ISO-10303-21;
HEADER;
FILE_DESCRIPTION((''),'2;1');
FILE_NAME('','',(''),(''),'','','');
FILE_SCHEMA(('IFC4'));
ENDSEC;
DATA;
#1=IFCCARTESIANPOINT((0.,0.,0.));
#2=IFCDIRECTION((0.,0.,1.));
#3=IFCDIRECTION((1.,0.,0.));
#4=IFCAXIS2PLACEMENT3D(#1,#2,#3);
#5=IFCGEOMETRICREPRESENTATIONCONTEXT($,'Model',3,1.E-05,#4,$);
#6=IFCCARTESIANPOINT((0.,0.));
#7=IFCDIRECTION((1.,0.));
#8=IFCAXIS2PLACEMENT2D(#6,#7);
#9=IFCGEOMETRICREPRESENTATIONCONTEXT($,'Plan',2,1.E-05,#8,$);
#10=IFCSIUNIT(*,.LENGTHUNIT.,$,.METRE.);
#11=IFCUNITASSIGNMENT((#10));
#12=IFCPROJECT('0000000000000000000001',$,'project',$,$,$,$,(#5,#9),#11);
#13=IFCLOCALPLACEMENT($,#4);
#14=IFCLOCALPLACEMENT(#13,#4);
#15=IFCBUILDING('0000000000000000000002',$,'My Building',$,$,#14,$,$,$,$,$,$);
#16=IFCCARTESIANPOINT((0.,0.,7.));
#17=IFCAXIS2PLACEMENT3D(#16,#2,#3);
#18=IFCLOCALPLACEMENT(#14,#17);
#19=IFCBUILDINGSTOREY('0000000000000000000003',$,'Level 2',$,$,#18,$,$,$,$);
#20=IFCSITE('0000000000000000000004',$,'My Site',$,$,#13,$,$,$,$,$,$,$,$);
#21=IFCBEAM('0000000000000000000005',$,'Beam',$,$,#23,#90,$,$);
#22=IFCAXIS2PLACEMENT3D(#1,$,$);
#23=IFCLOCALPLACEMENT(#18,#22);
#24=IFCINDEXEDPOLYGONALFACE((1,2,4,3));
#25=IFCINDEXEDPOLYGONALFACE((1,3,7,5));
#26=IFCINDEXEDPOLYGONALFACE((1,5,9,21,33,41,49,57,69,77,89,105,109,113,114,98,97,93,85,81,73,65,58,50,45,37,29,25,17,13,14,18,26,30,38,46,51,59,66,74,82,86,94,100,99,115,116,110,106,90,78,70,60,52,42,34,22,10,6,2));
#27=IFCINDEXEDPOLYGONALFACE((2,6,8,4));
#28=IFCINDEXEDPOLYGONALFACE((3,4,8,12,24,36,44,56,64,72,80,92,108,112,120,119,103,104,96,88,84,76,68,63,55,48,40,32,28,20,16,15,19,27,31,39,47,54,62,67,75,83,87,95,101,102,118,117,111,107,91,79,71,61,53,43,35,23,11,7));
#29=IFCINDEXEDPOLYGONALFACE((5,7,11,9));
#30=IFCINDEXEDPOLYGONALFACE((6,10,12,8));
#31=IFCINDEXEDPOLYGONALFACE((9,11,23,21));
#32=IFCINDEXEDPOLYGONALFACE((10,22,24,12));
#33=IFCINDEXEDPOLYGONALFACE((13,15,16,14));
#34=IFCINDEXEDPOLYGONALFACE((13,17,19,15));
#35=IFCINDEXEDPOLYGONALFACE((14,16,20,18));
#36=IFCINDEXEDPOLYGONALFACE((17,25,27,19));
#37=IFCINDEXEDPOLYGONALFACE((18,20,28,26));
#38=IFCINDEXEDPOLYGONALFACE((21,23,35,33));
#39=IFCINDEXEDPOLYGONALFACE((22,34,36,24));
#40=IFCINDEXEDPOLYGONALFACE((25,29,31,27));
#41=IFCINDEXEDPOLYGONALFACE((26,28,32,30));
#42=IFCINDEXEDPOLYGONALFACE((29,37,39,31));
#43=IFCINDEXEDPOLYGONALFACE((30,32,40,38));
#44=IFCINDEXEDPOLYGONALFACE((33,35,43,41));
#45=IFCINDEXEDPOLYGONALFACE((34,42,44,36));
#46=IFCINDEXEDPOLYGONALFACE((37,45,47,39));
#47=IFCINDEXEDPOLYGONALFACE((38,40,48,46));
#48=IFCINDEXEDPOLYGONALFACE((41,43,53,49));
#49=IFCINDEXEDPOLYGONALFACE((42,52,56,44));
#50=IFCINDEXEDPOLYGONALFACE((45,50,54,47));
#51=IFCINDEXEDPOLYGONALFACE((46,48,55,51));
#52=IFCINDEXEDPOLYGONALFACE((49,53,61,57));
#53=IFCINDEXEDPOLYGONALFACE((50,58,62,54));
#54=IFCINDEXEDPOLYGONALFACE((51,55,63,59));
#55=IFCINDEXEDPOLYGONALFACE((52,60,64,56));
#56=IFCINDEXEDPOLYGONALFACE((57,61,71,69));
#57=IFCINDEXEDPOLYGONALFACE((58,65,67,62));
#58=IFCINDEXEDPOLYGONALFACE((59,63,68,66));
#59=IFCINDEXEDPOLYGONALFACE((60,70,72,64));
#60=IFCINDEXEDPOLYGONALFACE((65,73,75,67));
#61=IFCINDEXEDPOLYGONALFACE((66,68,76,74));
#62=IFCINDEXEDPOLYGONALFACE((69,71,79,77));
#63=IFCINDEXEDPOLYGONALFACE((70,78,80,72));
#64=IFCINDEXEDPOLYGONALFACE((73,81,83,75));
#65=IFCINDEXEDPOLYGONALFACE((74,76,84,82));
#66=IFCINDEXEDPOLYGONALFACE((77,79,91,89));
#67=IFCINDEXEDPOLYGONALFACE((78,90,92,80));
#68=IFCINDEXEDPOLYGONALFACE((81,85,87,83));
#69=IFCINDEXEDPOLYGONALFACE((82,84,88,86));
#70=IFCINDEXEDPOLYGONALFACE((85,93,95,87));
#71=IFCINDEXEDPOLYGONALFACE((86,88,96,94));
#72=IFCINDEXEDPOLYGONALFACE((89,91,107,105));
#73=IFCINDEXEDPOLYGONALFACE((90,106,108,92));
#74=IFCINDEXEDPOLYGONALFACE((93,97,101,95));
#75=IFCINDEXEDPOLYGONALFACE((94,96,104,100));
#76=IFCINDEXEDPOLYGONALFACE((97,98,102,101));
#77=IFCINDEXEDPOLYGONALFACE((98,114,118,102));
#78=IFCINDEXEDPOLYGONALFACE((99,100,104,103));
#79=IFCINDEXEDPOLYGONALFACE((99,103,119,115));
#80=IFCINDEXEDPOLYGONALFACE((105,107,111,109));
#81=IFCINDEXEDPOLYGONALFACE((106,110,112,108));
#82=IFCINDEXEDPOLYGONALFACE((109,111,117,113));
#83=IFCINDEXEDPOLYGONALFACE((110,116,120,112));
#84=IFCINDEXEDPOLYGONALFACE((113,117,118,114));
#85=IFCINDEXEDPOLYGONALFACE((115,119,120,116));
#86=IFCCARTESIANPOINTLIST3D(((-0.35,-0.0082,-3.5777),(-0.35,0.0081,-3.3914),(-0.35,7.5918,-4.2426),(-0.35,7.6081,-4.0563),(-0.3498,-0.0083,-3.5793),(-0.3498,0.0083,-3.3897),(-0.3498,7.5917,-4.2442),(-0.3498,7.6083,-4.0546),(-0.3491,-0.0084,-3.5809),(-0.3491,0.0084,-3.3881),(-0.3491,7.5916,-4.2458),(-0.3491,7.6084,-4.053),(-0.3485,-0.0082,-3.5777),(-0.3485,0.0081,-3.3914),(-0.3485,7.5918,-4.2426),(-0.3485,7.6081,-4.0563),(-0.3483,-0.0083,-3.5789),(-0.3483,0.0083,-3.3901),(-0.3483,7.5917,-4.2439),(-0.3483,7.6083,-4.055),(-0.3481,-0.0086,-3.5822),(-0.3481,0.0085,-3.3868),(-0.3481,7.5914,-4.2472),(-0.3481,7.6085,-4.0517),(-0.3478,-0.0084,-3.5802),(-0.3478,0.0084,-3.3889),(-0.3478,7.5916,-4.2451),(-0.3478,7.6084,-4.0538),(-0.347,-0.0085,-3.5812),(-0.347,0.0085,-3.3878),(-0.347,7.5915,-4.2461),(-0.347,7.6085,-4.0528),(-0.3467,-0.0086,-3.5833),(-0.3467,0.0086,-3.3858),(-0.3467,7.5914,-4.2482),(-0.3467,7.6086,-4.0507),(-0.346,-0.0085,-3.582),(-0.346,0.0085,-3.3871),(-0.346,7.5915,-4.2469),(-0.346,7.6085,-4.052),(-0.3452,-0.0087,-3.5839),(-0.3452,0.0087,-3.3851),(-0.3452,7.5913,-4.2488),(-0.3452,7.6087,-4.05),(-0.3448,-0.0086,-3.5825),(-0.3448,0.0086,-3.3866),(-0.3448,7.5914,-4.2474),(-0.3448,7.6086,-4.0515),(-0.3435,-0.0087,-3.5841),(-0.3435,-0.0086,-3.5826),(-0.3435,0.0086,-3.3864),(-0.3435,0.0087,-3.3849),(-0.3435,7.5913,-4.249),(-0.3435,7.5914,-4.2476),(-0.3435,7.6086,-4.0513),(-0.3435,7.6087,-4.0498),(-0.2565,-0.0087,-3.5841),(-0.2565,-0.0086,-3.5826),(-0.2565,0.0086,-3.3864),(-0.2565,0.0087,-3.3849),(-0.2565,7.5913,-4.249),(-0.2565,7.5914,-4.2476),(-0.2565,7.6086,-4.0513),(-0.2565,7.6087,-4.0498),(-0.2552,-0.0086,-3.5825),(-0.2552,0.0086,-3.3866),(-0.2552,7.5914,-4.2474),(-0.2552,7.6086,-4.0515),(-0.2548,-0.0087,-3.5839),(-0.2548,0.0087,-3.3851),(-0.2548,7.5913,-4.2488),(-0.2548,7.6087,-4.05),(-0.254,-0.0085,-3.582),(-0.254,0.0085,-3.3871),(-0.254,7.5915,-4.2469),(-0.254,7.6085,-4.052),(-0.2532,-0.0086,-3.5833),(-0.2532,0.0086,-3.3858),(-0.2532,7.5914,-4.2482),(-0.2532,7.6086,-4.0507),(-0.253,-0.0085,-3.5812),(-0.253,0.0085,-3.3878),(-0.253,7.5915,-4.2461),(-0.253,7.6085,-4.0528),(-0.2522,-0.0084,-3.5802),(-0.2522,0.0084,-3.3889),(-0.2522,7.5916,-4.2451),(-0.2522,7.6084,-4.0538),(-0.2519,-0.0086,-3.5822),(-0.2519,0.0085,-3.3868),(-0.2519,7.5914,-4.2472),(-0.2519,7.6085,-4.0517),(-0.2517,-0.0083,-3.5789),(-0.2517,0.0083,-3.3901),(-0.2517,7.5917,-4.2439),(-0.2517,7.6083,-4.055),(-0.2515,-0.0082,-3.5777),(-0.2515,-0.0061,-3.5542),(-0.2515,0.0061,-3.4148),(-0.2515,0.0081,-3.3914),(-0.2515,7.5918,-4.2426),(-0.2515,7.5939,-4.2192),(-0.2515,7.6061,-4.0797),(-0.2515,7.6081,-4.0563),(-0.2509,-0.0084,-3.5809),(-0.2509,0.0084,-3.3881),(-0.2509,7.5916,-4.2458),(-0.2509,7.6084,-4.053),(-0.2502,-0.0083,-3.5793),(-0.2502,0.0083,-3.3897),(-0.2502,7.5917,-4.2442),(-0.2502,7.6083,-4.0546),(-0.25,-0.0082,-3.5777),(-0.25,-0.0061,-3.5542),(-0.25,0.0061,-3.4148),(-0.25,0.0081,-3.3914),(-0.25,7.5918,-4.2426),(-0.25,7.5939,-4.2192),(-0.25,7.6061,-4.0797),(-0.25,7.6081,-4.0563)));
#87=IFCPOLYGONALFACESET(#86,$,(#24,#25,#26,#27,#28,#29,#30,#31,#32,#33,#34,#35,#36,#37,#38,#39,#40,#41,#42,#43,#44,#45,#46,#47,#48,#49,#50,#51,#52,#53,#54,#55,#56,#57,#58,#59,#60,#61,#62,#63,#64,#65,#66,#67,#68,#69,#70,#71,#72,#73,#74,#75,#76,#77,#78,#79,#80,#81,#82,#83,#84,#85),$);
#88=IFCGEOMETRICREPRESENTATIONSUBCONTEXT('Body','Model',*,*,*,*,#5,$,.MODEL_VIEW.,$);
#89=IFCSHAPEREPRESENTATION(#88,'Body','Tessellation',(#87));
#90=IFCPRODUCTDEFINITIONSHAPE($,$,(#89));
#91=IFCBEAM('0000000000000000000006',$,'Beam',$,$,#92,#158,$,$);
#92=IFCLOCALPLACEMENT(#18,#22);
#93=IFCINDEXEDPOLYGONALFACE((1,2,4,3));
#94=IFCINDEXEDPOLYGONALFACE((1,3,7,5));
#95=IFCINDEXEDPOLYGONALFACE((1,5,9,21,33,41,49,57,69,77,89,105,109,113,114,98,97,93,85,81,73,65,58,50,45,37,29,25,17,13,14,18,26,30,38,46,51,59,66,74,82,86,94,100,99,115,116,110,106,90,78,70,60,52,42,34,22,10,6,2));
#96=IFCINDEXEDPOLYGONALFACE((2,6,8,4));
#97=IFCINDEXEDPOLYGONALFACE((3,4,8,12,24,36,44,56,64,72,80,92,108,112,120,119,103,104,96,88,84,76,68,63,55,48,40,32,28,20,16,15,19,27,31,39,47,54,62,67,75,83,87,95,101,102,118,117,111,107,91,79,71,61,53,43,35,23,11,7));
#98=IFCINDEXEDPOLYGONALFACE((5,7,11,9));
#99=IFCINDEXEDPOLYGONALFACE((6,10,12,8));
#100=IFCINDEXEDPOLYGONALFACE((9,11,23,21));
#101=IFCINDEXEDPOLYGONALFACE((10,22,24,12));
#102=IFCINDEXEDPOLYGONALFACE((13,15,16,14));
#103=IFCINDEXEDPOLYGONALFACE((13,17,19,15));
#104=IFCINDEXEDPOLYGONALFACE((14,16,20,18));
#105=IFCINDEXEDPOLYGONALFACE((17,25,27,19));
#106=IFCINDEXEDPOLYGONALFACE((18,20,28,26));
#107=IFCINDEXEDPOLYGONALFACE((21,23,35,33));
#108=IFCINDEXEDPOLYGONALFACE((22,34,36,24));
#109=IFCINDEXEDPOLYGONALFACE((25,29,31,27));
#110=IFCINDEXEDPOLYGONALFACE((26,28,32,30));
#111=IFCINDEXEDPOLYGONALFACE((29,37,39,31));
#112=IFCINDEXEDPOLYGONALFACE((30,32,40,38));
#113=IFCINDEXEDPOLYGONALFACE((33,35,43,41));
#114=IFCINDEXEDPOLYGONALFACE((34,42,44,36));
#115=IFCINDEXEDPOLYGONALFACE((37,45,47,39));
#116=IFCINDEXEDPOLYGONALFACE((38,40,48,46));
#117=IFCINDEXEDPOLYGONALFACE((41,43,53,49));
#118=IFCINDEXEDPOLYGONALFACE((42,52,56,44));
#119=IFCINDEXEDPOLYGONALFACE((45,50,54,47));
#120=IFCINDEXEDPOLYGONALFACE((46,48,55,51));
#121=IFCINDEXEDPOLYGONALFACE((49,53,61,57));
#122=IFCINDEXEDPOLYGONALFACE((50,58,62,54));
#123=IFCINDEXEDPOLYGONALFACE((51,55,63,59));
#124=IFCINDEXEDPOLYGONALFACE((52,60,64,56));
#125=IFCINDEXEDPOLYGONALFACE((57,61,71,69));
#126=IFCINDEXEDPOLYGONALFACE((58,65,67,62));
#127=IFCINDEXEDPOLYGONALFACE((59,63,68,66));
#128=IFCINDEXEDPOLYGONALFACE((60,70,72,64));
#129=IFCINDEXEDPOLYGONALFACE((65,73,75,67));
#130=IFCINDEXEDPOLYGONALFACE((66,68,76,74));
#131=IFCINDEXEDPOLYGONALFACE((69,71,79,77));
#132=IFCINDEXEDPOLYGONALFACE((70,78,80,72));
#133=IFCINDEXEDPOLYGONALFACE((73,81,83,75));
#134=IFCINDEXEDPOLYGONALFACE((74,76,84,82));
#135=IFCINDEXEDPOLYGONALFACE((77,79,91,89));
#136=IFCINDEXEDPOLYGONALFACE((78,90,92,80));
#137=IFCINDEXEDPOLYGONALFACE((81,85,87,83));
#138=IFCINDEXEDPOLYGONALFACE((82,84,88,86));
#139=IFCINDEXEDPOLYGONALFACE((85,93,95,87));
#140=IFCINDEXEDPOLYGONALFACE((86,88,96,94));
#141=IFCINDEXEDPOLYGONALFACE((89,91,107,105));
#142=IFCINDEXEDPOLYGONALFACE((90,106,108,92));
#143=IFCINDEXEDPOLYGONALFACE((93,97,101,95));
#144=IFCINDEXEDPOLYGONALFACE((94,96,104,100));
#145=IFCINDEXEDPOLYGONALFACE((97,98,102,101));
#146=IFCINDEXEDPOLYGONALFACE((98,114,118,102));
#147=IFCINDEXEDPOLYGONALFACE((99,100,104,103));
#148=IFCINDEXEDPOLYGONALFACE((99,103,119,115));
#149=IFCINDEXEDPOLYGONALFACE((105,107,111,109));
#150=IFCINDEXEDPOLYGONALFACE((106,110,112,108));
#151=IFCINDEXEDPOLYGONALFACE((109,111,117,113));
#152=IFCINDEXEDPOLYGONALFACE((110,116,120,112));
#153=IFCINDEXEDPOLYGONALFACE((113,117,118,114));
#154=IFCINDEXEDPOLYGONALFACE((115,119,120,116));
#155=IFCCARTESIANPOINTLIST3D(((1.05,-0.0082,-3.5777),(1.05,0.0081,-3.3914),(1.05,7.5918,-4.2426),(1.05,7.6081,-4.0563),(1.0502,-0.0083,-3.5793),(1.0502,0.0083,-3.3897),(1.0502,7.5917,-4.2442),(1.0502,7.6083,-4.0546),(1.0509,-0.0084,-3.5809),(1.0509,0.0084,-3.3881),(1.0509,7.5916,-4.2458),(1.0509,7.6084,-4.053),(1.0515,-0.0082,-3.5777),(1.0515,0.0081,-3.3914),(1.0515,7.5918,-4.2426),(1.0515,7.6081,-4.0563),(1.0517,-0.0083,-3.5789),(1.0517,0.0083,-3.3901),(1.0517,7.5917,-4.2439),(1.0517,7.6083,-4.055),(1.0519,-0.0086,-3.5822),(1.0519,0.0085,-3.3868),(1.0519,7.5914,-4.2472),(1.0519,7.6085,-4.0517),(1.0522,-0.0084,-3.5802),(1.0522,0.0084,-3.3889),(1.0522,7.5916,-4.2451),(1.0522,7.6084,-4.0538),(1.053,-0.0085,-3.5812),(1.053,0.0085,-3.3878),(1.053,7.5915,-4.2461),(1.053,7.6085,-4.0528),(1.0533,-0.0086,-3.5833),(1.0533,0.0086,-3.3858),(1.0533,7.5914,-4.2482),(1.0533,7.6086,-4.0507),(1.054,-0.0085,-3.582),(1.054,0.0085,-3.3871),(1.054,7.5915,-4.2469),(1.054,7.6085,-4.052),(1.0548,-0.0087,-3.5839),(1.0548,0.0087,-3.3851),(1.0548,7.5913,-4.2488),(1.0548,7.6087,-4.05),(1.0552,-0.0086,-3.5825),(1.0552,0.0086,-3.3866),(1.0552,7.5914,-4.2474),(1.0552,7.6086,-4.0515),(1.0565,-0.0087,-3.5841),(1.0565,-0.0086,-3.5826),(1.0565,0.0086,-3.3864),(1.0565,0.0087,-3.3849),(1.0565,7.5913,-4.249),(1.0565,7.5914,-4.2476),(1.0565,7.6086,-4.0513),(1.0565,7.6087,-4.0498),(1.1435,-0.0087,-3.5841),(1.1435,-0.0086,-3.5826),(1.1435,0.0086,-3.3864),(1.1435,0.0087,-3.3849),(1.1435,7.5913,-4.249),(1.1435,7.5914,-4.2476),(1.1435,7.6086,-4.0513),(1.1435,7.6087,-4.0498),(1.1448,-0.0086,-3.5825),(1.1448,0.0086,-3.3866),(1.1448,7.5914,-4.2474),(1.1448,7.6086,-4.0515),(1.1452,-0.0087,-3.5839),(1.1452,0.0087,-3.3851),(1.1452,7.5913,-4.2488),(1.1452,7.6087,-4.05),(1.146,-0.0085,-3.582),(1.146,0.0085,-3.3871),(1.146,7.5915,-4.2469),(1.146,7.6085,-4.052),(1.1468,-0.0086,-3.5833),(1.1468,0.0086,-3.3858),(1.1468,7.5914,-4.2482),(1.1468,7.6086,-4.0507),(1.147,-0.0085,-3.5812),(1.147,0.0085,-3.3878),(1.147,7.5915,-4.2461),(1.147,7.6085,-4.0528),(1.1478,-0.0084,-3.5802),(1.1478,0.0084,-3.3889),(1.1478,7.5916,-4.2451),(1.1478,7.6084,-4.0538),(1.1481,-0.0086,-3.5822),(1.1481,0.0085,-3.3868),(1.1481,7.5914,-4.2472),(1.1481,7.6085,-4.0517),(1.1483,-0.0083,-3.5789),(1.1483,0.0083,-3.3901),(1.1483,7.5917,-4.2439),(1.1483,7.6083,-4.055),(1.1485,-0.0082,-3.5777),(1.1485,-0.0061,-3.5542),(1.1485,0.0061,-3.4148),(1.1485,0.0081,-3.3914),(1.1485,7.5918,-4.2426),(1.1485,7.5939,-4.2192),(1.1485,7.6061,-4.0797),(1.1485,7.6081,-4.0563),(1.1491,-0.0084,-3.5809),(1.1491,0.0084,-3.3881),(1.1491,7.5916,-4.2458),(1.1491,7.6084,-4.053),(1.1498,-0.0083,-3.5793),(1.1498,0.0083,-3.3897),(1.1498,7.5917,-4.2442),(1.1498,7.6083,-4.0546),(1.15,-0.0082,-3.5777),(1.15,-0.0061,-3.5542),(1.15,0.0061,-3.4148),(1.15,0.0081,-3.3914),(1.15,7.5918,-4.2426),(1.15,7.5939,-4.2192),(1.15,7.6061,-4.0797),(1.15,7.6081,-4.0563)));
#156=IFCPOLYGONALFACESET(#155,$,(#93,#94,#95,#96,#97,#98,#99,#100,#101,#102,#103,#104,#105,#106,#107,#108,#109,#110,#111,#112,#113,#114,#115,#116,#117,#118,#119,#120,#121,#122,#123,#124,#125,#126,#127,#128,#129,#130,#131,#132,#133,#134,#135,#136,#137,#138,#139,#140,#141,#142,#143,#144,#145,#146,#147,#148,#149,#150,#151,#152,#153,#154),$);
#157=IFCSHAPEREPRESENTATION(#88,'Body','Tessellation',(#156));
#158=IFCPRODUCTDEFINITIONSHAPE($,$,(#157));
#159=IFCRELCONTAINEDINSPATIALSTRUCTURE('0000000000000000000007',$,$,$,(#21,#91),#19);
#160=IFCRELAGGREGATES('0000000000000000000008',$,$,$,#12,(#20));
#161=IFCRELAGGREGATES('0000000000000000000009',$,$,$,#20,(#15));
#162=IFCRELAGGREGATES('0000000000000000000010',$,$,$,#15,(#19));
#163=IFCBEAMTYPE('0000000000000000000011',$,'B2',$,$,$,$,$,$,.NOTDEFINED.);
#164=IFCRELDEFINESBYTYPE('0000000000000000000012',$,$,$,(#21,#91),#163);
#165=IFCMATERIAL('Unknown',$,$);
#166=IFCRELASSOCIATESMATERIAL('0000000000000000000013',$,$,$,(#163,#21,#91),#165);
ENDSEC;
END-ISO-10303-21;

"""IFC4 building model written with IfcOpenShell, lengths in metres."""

from ifc_helpers import new_model, si_unit, frame, origin_with_axes, origin_2d_with_axis, place, context, subcontext, project, spatial, c_section, extrude, material, material_profile, profile_set, profile_usage, type_object, element, save


model = new_model("IFC4")

# Units and contexts
model_context = context("Model", 3, precision=1e-05, world=origin_with_axes())
plan_context = context("Plan", 2, precision=1e-05, world=origin_2d_with_axis())
body_context = subcontext(model_context, "Body", "Model", "MODEL_VIEW")
ifc_project = project(units=[si_unit("LENGTHUNIT", "METRE")], contexts=[model_context, plan_context])

# Site, building, storey
site_placement = place(None, origin_with_axes())
site = spatial("IfcSite", under=ifc_project, at=site_placement, Name="My Site")
building_placement = place(site_placement, origin_with_axes())
building = spatial("IfcBuilding", under=site, at=building_placement, Name="My Building")
storey_placement = place(building_placement, frame((0.0, 0.0, 7.0), z_axis=(0.0, 0.0, 1.0), x_axis=(1.0, 0.0, 0.0)))
storey = spatial("IfcBuildingStorey", under=building, at=storey_placement, Name="Level 2")

# Shared definitions
ifc_material = material(Name="Unknown")

# Beams
ifc_material_profile_1 = material_profile(ifc_material, c_section(Depth=0.2, Width=0.1, WallThickness=0.0015, Girth=0.03, InternalFilletRadius=0.005))
ifc_profile_set_1 = profile_set([ifc_material_profile_1])
beam_type_1 = type_object("IfcBeamType", Name="B2", PredefinedType="NOTDEFINED", material=ifc_profile_set_1)
ifc_profile_usage_1 = profile_usage(ifc_profile_set_1, cardinal=5)
beam_1_placement = place(storey_placement, frame((-0.3, 7.6, -4.1494), z_axis=(0.0, -0.996195, 0.087156), x_axis=(1.0, 0.0, 0.0)))
element("IfcBeam", 1, at=beam_1_placement, inside=storey, type_object=beam_type_1, material=ifc_profile_usage_1, Name="Beam", context=body_context, shape_type="SweptSolid", body=[
    extrude(c_section(Depth=0.2, Width=0.1, WallThickness=0.0015, Girth=0.03, InternalFilletRadius=0.005), origin_with_axes(), (0.0, 0.0, 1.0), 7.629),
])
ifc_profile_usage_2 = profile_usage(ifc_profile_set_1, cardinal=5)
beam_2_placement = place(storey_placement, frame((1.1, 7.6, -4.1494), z_axis=(0.0, -0.996195, 0.087156), x_axis=(1.0, 0.0, 0.0)))
element("IfcBeam", 2, at=beam_2_placement, inside=storey, type_object=beam_type_1, material=ifc_profile_usage_2, Name="Beam", context=body_context, shape_type="SweptSolid", body=[
    extrude(c_section(Depth=0.2, Width=0.1, WallThickness=0.0015, Girth=0.03, InternalFilletRadius=0.005), origin_with_axes(), (0.0, 0.0, 1.0), 7.629),
])

save(model, "model.ifc")
